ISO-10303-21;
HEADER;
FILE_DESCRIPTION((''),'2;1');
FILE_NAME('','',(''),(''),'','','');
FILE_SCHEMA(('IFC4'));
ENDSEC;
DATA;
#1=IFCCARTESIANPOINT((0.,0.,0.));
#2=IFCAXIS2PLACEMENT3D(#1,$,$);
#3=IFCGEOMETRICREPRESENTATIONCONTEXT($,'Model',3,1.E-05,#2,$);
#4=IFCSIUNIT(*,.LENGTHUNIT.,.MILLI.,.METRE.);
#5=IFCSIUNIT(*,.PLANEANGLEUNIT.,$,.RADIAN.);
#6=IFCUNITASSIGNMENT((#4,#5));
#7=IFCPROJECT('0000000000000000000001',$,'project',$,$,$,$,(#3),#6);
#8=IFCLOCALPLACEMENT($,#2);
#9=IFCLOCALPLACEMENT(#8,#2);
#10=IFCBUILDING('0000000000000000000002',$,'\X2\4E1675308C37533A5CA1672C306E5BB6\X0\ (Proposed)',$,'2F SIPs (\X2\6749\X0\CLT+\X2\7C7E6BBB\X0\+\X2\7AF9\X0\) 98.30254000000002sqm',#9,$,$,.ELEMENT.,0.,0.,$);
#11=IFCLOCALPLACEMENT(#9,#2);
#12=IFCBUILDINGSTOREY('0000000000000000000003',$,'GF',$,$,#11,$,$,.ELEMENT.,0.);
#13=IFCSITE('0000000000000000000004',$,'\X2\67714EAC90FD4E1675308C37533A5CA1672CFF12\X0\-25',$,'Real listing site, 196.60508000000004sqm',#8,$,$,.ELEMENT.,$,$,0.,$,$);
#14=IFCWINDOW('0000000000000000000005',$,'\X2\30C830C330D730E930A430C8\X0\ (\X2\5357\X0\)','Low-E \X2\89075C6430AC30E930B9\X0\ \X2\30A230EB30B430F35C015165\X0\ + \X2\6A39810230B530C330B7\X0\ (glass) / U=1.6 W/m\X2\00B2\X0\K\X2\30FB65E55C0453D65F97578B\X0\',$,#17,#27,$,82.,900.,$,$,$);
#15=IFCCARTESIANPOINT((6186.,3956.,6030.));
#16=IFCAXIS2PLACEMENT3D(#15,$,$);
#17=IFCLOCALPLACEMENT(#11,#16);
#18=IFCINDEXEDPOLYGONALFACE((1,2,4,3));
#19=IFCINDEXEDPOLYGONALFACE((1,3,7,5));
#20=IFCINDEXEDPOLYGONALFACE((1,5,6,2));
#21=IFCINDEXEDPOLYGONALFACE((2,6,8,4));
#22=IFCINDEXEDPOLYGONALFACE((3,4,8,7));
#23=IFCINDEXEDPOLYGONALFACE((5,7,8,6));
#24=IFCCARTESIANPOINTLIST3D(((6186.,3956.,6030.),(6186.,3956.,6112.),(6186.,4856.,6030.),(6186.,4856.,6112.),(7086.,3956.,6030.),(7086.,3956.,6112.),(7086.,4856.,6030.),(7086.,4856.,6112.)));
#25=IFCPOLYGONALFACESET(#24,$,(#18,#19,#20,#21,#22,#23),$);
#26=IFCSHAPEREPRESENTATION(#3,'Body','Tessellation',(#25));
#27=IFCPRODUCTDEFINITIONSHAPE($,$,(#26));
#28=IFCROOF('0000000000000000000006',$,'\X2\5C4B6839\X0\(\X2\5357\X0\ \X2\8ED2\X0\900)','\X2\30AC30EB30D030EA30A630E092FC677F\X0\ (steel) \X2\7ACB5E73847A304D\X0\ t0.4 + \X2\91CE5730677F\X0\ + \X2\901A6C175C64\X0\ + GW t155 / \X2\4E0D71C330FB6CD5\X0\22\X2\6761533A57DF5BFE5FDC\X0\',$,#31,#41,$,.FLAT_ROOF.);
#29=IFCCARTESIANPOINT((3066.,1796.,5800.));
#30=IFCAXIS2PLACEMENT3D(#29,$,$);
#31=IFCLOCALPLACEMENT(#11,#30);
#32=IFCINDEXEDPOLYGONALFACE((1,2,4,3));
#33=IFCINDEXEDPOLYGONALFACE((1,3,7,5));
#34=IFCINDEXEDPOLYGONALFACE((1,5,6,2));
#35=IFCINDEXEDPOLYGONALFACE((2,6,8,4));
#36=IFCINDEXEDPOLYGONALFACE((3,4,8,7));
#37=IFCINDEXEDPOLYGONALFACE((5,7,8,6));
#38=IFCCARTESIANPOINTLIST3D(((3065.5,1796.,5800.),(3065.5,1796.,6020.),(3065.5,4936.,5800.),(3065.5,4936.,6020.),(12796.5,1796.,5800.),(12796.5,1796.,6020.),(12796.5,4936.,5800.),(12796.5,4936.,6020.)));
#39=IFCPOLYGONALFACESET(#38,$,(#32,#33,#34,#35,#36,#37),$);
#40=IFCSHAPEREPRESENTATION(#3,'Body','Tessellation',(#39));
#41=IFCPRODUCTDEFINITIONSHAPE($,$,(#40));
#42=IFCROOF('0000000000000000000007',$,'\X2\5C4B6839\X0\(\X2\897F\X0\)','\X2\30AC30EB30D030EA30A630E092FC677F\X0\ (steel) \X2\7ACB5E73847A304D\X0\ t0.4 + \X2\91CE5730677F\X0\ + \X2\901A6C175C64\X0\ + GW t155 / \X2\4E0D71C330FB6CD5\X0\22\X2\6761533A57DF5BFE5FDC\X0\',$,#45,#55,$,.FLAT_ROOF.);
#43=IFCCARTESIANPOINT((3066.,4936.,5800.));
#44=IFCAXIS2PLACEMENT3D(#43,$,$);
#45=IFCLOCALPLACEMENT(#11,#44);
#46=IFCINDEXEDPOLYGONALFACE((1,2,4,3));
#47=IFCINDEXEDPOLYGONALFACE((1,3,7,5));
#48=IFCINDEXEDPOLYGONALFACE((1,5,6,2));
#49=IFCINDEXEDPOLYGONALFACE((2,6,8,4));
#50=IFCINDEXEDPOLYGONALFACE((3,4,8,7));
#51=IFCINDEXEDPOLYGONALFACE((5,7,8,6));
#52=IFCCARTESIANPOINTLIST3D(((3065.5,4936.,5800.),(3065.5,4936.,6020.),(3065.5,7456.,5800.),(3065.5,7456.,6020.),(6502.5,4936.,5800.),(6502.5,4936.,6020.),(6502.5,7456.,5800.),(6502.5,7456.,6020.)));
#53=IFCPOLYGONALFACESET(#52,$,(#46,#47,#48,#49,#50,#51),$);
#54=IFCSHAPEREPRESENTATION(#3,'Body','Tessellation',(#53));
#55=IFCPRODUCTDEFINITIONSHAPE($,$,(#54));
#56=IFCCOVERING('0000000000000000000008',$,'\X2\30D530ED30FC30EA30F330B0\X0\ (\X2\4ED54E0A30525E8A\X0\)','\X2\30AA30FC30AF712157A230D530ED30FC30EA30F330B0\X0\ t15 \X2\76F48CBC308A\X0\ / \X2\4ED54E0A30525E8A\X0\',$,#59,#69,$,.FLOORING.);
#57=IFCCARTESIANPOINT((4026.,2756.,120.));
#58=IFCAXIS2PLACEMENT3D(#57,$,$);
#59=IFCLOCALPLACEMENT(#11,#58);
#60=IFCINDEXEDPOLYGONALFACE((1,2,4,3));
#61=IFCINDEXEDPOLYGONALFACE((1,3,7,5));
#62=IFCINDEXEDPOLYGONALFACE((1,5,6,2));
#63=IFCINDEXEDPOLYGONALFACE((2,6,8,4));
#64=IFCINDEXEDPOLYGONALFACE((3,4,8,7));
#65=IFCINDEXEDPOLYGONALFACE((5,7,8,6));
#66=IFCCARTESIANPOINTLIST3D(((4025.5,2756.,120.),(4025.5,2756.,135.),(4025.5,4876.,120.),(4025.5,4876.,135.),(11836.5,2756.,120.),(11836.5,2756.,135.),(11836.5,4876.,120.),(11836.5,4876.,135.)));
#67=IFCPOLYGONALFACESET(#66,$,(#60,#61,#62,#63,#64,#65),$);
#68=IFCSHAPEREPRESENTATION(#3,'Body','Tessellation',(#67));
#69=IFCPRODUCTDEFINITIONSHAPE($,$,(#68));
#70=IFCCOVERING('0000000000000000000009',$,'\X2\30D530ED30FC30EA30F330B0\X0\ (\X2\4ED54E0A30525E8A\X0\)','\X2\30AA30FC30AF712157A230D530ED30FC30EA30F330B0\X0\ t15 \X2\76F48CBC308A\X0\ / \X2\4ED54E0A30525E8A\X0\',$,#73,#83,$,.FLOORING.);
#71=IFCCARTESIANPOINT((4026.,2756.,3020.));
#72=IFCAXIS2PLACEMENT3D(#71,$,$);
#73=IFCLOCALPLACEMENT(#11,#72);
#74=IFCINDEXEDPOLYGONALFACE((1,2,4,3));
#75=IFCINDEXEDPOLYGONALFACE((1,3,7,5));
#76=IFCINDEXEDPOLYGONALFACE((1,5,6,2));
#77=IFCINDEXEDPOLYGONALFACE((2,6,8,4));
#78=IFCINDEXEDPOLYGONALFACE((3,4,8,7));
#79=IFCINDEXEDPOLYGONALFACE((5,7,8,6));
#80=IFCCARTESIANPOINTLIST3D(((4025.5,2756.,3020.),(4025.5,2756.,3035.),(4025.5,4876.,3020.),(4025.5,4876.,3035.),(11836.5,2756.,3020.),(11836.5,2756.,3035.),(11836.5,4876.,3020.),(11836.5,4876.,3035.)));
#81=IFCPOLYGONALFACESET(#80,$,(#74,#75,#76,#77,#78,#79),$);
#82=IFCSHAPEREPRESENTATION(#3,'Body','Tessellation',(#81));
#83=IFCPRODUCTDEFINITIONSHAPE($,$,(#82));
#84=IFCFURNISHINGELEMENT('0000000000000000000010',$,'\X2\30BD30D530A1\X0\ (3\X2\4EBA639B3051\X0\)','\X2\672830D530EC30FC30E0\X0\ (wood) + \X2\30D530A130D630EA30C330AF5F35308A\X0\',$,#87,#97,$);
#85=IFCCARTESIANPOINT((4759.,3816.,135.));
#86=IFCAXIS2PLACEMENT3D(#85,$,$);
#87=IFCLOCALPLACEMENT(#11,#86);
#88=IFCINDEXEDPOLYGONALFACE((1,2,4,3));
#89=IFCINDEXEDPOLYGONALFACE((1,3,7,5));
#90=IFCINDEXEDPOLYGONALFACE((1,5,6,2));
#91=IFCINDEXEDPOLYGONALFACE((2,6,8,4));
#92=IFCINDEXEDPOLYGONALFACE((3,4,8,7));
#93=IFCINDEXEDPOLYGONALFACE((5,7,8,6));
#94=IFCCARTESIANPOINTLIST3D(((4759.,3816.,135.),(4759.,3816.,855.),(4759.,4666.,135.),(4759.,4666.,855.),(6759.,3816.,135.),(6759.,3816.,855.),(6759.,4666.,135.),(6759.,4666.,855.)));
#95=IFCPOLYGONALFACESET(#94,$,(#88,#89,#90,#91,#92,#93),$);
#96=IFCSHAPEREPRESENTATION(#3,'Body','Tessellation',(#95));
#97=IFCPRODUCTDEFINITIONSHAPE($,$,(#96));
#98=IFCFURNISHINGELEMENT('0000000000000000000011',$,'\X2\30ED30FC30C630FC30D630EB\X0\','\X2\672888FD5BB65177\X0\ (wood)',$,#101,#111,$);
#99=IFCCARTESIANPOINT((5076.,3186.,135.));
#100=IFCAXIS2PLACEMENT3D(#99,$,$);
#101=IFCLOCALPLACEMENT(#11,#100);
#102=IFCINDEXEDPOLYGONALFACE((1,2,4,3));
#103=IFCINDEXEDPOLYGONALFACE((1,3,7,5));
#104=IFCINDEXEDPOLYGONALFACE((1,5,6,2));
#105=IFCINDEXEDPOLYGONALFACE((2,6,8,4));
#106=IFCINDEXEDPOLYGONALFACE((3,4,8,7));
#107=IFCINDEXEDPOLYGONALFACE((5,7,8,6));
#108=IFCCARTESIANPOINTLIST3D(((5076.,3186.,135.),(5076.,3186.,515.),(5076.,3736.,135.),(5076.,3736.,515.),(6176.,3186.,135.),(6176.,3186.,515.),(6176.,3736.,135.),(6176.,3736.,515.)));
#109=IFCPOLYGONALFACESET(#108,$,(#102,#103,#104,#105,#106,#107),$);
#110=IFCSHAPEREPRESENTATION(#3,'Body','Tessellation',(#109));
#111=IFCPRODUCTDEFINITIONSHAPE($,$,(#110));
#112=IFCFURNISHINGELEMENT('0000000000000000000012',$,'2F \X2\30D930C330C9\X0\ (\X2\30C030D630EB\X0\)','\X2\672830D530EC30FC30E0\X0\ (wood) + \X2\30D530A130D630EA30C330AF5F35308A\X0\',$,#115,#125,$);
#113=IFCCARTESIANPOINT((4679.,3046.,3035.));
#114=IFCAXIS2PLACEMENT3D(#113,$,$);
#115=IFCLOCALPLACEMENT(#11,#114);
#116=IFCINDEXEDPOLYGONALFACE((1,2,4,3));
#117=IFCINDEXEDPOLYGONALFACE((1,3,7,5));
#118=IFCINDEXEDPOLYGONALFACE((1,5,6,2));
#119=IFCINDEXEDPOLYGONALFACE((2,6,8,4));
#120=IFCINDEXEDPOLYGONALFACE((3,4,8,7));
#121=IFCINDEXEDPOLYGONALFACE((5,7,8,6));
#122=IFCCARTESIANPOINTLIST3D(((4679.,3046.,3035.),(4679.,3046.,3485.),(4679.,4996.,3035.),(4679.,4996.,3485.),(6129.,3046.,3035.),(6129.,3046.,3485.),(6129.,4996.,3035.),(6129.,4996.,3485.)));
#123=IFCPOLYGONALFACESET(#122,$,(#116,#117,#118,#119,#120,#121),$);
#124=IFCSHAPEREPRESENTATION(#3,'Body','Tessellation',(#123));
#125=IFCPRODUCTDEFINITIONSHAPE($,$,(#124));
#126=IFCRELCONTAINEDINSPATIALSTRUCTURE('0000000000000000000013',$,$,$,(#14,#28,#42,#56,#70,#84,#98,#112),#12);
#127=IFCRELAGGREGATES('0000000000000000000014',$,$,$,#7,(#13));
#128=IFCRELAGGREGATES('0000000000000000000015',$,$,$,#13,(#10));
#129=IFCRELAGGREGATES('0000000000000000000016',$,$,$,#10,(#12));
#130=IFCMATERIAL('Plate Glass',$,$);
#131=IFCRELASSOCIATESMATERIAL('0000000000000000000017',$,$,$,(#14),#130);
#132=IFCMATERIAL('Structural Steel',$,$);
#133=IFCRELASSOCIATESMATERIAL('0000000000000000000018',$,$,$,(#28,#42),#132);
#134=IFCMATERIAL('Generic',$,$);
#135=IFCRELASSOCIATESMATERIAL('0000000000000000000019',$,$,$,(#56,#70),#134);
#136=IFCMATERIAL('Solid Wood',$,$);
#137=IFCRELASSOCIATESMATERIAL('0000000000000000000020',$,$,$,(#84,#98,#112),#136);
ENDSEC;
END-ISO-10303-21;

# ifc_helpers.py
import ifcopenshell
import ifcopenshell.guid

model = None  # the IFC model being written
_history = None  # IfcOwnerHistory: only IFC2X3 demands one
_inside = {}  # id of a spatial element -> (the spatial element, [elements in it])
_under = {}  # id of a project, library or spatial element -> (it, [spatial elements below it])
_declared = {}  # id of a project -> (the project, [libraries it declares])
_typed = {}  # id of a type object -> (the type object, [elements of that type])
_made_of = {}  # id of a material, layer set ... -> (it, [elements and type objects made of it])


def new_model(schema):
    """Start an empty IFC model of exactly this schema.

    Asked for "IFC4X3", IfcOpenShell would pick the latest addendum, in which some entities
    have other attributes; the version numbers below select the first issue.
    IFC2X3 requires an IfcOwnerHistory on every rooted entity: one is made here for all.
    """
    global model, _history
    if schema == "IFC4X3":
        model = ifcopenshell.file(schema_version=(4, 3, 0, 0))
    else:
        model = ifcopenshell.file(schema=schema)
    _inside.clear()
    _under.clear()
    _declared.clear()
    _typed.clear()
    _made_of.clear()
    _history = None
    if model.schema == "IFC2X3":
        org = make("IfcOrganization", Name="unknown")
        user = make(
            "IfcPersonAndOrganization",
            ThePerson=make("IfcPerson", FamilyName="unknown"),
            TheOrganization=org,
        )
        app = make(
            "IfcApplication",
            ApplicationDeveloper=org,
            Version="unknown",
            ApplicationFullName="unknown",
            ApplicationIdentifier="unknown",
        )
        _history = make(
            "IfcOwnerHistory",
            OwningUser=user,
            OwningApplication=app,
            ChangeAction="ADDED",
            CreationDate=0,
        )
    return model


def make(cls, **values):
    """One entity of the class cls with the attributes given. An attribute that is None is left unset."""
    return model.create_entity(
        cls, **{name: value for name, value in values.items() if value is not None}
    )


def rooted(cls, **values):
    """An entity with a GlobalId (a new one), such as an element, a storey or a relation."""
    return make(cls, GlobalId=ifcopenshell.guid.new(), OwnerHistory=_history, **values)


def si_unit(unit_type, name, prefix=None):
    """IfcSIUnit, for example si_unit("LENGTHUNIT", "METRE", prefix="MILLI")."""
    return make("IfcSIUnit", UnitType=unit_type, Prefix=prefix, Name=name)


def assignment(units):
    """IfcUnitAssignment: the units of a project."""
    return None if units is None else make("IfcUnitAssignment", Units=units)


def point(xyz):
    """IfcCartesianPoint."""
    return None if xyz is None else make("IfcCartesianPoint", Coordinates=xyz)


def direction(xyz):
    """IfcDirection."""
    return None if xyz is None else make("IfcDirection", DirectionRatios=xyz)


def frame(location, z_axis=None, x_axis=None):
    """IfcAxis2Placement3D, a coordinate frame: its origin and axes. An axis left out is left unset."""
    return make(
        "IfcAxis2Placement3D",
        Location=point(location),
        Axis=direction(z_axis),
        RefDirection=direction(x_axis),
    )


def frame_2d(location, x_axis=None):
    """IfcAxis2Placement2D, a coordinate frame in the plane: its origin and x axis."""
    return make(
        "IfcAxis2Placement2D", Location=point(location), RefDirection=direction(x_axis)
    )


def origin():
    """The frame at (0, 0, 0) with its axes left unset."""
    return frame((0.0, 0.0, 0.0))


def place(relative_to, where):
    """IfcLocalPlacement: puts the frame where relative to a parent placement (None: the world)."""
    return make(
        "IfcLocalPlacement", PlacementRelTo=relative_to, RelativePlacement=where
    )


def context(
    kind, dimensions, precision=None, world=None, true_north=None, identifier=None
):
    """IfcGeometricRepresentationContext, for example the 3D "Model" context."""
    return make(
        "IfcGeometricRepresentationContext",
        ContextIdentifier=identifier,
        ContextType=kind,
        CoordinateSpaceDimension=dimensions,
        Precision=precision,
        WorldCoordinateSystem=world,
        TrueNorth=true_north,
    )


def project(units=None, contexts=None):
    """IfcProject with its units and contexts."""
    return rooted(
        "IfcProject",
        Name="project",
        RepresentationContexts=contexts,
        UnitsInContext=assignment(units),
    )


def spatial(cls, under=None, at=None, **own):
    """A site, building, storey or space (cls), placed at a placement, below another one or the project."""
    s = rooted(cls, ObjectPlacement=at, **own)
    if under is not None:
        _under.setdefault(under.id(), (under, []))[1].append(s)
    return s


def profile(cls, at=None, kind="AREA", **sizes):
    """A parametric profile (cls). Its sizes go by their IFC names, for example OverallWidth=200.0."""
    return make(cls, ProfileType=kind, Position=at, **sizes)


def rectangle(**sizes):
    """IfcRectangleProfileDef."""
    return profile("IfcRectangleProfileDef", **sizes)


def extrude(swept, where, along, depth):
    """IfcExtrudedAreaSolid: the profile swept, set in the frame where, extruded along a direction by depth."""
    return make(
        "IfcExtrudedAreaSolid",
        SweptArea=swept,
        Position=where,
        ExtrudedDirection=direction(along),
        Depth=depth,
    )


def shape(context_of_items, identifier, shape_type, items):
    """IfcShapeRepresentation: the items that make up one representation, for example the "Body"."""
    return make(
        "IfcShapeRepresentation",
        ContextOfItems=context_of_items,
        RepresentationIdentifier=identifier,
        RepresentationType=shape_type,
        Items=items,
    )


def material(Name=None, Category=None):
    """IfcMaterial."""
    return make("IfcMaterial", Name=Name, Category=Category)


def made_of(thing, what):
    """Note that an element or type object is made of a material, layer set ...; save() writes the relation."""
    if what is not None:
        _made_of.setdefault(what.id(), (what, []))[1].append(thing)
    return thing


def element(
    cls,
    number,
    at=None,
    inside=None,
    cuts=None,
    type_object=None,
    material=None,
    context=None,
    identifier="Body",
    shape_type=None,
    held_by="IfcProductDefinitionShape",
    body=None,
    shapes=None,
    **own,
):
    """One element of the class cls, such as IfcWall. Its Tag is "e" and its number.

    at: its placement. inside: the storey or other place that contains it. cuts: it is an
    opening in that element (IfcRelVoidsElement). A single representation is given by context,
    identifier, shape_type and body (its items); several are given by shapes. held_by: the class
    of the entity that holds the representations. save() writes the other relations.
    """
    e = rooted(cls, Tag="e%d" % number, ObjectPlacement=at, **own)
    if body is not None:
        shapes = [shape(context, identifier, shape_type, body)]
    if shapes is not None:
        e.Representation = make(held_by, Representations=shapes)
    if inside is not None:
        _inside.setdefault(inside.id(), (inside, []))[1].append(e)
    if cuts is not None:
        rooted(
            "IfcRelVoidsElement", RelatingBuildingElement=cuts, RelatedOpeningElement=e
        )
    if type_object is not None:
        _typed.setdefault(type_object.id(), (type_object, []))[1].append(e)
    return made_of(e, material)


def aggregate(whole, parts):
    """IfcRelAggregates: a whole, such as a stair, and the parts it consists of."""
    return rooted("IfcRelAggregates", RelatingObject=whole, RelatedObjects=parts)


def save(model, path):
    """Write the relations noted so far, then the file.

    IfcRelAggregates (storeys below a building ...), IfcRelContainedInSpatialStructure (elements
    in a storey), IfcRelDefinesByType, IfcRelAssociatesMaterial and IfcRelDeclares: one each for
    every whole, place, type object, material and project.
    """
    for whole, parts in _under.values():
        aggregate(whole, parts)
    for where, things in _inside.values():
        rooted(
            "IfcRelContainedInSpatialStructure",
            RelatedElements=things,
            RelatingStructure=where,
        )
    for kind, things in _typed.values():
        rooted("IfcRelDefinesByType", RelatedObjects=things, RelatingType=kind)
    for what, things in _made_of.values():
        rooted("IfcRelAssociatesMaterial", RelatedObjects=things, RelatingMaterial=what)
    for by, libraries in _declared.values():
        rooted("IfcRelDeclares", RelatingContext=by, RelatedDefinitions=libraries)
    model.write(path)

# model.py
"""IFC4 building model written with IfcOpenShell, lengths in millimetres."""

from ifc_helpers import new_model, si_unit, frame, frame_2d, origin, place, context, project, spatial, rectangle, extrude, material, element, save


model = new_model("IFC4")

# Units and contexts
model_context = context("Model", 3, precision=1e-05, world=origin())
ifc_project = project(units=[si_unit("LENGTHUNIT", "METRE", prefix="MILLI"), si_unit("PLANEANGLEUNIT", "RADIAN")], contexts=[model_context])

# Site, building, storey
site_placement = place(None, origin())
site = spatial("IfcSite", under=ifc_project, at=site_placement, Name="東京都世田谷区岡本２-25", ObjectType="Real listing site, 196.60508000000004sqm", CompositionType="ELEMENT", RefElevation=0.0)
building_placement = place(site_placement, origin())
building = spatial("IfcBuilding", under=site, at=building_placement, Name="世田谷区岡本の家 (Proposed)", ObjectType="2F SIPs (杉CLT+籾殻+竹) 98.30254000000002sqm", CompositionType="ELEMENT", ElevationOfRefHeight=0.0, ElevationOfTerrain=0.0)
storey_placement = place(building_placement, origin())
storey = spatial("IfcBuildingStorey", under=building, at=storey_placement, Name="GF", CompositionType="ELEMENT", Elevation=0.0)

# Shared definitions
ifc_material_1 = material(Name="Solid Wood")

# Shared definitions
ifc_material_2 = material(Name="Plate Glass")

# Window
window_1_placement = place(storey_placement, frame((6186.0, 3956.0, 6030.0)))
element("IfcWindow", 1, at=window_1_placement, inside=storey, material=ifc_material_2, Name="トップライト (南)", Description="Low-E 複層ガラス アルゴン封入 + 樹脂サッシ (glass) / U=1.6 W/m²K・日射取得型", OverallHeight=82.0, OverallWidth=900.0, context=model_context, shape_type="SweptSolid", body=[
    extrude(rectangle(XDim=900.0, YDim=900.0, at=frame_2d((450.0, 450.0))), frame((6186.0, 3956.0, 6030.0)), (0.0, 0.0, 1.0), 82.0),
])

# Roofs
ifc_material_3 = material(Name="Structural Steel")
roof_1_placement = place(storey_placement, frame((3066.0, 1796.0, 5800.0)))
element("IfcRoof", 2, at=roof_1_placement, inside=storey, material=ifc_material_3, Name="屋根(南 軒900)", Description="ガルバリウム鋼板 (steel) 立平葺き t0.4 + 野地板 + 通気層 + GW t155 / 不燃・法22条区域対応", PredefinedType="FLAT_ROOF", context=model_context, shape_type="SweptSolid", body=[
    extrude(rectangle(XDim=9731.0, YDim=3140.0, at=frame_2d((4865.0, 1570.0))), frame((3066.0, 1796.0, 5800.0)), (0.0, 0.0, 1.0), 220.0),
])
roof_2_placement = place(storey_placement, frame((3066.0, 4936.0, 5800.0)))
element("IfcRoof", 3, at=roof_2_placement, inside=storey, material=ifc_material_3, Name="屋根(西)", Description="ガルバリウム鋼板 (steel) 立平葺き t0.4 + 野地板 + 通気層 + GW t155 / 不燃・法22条区域対応", PredefinedType="FLAT_ROOF", context=model_context, shape_type="SweptSolid", body=[
    extrude(rectangle(XDim=3437.0, YDim=2520.0, at=frame_2d((1718.0, 1260.0))), frame((3066.0, 4936.0, 5800.0)), (0.0, 0.0, 1.0), 220.0),
])

# Coverings
ifc_material_4 = material(Name="Generic")
covering_1_placement = place(storey_placement, frame((4026.0, 2756.0, 120.0)))
element("IfcCovering", 4, at=covering_1_placement, inside=storey, material=ifc_material_4, Name="フローリング (仕上げ床)", Description="オーク無垢フローリング t15 直貼り / 仕上げ床", PredefinedType="FLOORING", context=model_context, shape_type="SweptSolid", body=[
    extrude(rectangle(XDim=7811.0, YDim=2120.0, at=frame_2d((3905.0, 1060.0))), frame((4026.0, 2756.0, 120.0)), (0.0, 0.0, 1.0), 15.0),
])
covering_2_placement = place(storey_placement, frame((4026.0, 2756.0, 3020.0)))
element("IfcCovering", 5, at=covering_2_placement, inside=storey, material=ifc_material_4, Name="フローリング (仕上げ床)", Description="オーク無垢フローリング t15 直貼り / 仕上げ床", PredefinedType="FLOORING", context=model_context, shape_type="SweptSolid", body=[
    extrude(rectangle(XDim=7811.0, YDim=2120.0, at=frame_2d((3905.0, 1060.0))), frame((4026.0, 2756.0, 3020.0)), (0.0, 0.0, 1.0), 15.0),
])

# Furnishing elements
furnishing_1_placement = place(storey_placement, frame((4759.0, 3816.0, 135.0)))
element("IfcFurnishingElement", 6, at=furnishing_1_placement, inside=storey, material=ifc_material_1, Name="ソファ (3人掛け)", Description="木フレーム (wood) + ファブリック張り", context=model_context, shape_type="SweptSolid", body=[
    extrude(rectangle(XDim=2000.0, YDim=850.0, at=frame_2d((1000.0, 425.0))), frame((4759.0, 3816.0, 135.0)), (0.0, 0.0, 1.0), 720.0),
])
furnishing_2_placement = place(storey_placement, frame((5076.0, 3186.0, 135.0)))
element("IfcFurnishingElement", 7, at=furnishing_2_placement, inside=storey, material=ifc_material_1, Name="ローテーブル", Description="木製家具 (wood)", context=model_context, shape_type="SweptSolid", body=[
    extrude(rectangle(XDim=1100.0, YDim=550.0, at=frame_2d((550.0, 275.0))), frame((5076.0, 3186.0, 135.0)), (0.0, 0.0, 1.0), 380.0),
])
furnishing_3_placement = place(storey_placement, frame((4679.0, 3046.0, 3035.0)))
element("IfcFurnishingElement", 8, at=furnishing_3_placement, inside=storey, material=ifc_material_1, Name="2F ベッド (ダブル)", Description="木フレーム (wood) + ファブリック張り", context=model_context, shape_type="SweptSolid", body=[
    extrude(rectangle(XDim=1450.0, YDim=1950.0, at=frame_2d((725.0, 975.0))), frame((4679.0, 3046.0, 3035.0)), (0.0, 0.0, 1.0), 450.0),
])

save(model, "model.ifc")
